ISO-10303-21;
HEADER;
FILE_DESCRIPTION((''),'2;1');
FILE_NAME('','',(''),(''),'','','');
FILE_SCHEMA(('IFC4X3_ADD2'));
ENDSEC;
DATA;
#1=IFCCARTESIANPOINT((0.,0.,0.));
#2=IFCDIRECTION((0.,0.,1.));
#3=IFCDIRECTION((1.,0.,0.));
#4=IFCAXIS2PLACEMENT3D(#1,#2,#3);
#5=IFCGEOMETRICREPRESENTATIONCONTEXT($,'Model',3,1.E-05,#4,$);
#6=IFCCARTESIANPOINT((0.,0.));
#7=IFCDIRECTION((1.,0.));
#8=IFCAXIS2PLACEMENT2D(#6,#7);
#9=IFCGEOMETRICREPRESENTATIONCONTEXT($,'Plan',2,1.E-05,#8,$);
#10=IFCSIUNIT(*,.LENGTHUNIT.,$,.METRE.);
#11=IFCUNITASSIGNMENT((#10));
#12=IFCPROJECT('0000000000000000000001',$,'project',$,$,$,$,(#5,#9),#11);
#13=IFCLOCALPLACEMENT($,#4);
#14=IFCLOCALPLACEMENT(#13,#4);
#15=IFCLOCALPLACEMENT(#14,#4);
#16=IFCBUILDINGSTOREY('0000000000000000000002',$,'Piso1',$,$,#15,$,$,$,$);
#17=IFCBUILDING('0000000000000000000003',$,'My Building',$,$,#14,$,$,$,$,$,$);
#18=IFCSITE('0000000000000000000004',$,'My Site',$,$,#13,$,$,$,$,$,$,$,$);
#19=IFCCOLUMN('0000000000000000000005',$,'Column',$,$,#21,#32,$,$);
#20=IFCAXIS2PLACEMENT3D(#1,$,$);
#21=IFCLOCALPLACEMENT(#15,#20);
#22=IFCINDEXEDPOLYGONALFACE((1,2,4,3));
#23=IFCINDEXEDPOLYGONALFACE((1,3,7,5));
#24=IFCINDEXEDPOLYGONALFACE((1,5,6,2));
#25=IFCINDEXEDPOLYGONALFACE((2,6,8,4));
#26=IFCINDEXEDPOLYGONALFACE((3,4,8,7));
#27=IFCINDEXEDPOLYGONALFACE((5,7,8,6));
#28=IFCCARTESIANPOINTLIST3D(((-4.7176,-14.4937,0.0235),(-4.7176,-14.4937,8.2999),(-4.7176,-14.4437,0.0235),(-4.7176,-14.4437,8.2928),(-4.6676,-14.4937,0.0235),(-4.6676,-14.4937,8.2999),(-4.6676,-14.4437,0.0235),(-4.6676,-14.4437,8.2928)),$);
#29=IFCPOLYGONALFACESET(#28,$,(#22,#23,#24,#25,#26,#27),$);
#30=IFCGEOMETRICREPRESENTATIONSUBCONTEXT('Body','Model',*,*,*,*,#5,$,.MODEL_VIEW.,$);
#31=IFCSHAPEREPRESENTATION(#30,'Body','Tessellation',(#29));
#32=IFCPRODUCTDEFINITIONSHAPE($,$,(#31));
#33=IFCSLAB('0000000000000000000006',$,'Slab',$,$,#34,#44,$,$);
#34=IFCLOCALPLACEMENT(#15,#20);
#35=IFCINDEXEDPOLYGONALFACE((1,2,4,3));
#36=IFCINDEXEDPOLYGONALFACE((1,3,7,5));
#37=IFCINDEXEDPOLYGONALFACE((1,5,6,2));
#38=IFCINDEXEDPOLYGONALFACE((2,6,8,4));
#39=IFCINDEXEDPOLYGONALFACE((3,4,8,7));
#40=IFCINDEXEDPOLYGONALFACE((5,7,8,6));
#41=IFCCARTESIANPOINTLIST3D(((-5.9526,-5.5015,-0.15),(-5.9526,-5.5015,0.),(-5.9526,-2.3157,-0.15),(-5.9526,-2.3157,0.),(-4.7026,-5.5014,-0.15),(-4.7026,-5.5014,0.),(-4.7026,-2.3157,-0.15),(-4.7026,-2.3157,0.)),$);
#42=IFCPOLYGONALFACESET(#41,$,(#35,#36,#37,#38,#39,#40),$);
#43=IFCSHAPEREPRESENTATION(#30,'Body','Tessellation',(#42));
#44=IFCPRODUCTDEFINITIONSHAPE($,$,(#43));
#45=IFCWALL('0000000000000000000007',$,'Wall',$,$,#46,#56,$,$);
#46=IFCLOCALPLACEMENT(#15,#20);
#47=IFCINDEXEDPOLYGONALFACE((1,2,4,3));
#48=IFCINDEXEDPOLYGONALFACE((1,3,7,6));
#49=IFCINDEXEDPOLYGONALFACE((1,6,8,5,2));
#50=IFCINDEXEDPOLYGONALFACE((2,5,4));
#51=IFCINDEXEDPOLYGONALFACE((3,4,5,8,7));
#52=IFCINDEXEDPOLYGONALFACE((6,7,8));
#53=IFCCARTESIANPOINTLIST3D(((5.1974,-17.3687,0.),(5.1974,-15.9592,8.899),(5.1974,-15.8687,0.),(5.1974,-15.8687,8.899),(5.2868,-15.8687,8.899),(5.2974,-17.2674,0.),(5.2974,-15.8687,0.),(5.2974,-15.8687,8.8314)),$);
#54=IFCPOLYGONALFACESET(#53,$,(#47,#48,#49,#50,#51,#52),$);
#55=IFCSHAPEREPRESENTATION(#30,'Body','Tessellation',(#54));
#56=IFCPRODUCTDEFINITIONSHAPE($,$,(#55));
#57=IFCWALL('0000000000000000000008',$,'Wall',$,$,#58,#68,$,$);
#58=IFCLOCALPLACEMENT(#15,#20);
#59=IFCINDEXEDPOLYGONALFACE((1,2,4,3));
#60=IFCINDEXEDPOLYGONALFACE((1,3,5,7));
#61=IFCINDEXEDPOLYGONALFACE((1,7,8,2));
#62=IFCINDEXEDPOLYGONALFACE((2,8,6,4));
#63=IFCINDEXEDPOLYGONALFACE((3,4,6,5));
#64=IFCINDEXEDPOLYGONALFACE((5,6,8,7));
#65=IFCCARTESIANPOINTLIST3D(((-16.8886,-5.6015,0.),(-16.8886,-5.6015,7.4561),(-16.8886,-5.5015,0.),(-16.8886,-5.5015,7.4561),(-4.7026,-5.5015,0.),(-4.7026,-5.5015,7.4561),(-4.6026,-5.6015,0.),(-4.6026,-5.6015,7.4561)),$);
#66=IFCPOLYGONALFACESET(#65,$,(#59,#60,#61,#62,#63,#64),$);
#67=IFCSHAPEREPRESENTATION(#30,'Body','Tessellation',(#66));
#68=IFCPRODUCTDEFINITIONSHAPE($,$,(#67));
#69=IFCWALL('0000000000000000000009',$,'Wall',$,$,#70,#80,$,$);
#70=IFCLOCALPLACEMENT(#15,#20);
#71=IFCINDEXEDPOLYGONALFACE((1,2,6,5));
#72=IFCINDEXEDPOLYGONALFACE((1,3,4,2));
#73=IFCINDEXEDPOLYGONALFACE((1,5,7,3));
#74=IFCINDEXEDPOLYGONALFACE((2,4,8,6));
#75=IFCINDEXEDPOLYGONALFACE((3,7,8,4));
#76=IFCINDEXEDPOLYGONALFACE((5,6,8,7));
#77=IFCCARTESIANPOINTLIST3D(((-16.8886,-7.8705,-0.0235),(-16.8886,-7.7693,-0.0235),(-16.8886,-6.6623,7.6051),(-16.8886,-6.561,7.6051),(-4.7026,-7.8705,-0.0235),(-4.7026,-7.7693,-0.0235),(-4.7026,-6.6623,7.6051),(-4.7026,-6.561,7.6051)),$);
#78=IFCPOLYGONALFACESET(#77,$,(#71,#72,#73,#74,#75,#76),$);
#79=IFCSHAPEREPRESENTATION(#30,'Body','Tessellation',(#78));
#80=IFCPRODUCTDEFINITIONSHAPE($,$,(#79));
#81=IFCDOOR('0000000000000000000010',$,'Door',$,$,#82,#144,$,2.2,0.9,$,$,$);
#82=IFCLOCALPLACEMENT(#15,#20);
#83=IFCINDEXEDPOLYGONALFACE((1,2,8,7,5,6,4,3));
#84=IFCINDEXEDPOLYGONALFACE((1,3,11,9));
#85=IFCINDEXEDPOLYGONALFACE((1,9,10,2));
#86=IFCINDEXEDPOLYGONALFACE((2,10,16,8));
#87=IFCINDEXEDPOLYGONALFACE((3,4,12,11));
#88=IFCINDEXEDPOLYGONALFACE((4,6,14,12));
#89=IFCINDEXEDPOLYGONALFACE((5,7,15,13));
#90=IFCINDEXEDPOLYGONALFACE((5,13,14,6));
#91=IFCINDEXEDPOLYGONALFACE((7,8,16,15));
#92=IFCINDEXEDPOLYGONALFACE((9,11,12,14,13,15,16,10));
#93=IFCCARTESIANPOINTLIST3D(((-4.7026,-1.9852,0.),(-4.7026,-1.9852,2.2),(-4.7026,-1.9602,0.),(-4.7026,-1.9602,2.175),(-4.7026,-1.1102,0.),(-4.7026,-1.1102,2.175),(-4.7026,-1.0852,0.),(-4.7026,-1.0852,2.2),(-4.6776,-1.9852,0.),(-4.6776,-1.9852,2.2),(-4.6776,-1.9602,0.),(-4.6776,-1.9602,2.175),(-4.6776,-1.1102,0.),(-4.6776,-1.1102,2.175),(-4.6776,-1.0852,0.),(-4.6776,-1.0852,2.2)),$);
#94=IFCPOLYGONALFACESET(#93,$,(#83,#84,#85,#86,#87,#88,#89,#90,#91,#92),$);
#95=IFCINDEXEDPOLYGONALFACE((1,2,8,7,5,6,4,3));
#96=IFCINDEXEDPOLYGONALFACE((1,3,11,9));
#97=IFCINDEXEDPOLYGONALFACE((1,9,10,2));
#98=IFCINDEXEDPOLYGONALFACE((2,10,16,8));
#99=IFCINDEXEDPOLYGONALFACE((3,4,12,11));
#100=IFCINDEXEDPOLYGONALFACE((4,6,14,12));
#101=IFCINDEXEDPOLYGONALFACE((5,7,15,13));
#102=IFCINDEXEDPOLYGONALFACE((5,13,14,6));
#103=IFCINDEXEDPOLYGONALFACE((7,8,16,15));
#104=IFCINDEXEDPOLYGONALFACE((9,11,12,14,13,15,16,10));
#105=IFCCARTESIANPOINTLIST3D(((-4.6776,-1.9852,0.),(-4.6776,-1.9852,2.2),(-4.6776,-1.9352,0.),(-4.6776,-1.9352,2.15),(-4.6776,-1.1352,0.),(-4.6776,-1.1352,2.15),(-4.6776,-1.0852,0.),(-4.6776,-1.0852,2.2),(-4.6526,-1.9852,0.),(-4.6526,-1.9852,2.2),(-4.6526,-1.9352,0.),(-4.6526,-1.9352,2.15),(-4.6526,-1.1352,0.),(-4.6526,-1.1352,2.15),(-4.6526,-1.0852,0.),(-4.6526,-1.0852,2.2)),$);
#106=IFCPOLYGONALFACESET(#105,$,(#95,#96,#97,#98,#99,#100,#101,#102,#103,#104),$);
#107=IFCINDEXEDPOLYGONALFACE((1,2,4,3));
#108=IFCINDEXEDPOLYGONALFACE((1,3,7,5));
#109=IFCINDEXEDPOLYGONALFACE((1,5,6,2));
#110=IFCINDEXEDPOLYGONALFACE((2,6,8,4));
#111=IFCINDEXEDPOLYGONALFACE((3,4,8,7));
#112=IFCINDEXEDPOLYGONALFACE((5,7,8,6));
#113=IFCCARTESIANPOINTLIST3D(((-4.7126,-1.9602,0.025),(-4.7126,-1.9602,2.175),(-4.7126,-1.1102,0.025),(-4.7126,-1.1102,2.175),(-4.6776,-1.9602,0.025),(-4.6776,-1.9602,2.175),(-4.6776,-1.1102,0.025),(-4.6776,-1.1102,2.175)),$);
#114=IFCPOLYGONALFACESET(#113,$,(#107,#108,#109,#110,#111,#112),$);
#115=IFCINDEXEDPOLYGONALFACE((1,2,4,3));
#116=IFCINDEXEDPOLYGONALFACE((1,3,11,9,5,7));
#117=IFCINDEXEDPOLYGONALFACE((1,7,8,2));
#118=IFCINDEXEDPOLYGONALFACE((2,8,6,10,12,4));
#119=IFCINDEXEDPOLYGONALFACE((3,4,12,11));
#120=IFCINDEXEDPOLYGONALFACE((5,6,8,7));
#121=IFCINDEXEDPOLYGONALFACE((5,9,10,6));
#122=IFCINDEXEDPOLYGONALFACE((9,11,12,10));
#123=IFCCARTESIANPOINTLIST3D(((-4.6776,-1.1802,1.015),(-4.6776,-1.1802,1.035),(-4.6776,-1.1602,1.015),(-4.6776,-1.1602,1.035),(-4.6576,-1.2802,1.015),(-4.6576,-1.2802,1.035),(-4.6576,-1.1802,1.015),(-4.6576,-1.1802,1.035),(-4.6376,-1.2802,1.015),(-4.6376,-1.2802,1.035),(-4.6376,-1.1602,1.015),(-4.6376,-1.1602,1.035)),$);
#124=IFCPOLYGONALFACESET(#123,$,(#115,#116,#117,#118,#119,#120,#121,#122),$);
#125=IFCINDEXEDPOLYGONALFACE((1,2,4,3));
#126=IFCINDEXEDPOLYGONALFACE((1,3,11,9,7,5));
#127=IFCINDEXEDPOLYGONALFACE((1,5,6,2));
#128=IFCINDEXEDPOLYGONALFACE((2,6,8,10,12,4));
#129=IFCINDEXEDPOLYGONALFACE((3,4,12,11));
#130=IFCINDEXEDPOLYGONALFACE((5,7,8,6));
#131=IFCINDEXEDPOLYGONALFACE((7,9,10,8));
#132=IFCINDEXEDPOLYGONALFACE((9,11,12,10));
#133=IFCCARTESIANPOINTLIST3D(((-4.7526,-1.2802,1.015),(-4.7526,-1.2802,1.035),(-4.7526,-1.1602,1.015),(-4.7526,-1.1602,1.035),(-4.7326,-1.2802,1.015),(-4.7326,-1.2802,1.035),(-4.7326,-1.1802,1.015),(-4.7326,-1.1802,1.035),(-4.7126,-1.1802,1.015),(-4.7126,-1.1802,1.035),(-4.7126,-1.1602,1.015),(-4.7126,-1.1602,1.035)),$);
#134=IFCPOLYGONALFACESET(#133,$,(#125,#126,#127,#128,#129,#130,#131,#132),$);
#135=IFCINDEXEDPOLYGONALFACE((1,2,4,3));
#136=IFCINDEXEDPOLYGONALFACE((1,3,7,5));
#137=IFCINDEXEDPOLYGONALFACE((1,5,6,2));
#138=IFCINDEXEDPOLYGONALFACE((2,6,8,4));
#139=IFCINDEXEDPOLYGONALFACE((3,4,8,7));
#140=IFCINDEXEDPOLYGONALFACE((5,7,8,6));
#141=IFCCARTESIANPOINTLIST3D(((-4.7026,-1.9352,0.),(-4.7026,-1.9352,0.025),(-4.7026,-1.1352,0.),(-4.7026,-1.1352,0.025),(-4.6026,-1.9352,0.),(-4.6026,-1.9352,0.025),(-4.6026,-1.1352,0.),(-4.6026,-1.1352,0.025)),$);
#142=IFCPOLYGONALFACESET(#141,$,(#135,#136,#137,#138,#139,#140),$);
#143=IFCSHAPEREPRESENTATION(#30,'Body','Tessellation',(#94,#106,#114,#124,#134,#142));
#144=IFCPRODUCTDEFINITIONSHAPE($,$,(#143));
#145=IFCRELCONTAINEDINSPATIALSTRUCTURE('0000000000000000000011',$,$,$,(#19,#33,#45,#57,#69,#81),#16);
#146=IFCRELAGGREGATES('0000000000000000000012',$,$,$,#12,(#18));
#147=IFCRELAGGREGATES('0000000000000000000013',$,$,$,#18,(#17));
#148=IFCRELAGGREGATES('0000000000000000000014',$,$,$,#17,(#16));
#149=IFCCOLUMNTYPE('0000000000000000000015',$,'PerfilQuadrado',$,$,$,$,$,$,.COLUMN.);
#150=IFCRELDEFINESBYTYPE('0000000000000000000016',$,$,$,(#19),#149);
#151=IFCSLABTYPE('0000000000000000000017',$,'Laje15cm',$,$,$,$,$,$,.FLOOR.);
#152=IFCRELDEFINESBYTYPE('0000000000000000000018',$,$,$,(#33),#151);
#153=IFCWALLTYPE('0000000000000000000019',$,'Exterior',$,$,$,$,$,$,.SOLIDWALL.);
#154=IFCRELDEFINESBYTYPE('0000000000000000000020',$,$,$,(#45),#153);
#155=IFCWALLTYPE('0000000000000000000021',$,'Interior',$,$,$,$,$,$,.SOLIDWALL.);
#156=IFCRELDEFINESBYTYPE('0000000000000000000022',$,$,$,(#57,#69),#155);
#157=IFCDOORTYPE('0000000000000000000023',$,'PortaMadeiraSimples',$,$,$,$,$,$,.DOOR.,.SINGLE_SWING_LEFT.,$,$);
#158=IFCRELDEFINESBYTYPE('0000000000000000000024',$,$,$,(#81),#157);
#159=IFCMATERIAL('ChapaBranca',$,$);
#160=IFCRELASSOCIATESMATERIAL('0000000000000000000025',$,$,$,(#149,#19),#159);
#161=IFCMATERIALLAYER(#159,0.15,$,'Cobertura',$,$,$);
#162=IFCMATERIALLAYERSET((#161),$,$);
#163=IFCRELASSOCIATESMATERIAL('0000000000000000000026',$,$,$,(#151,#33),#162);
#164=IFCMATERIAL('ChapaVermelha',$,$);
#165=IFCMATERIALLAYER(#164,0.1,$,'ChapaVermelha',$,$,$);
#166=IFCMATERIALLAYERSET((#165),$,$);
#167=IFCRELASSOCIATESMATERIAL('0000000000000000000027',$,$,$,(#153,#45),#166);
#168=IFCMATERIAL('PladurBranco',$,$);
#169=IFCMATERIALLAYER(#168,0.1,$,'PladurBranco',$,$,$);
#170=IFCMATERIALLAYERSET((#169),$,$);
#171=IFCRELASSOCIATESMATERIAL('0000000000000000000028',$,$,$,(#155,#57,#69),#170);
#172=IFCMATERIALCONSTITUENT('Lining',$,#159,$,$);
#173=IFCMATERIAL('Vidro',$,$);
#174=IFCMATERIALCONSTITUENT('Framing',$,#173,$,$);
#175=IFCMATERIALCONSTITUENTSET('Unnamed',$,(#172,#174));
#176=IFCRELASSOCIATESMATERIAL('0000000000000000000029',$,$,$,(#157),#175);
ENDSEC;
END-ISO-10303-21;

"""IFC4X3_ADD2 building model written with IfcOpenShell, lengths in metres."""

from ifc_helpers import new_model, entity, si_unit, frame, origin_with_axes, origin_2d, origin_2d_with_axis, place, context, subcontext, project, spatial, line, indexed_curve, rectangle, outline, extrude, boolean, clip, halfspace, shape, source, transform, mapped, material, layer, layer_set, layer_usage, constituent, constituent_set, material_profile, profile_set, profile_usage, type_object, type_shapes, element, save


model = new_model("IFC4X3_ADD2")

# Units and contexts
model_context = context("Model", 3, precision=1e-05, world=origin_with_axes())
plan_context = context("Plan", 2, precision=1e-05, world=origin_2d_with_axis())
body_context_1 = subcontext(model_context, "Body", "Model", "MODEL_VIEW")
body_context_2 = subcontext(plan_context, "Body", "Plan", "PLAN_VIEW")
ifc_project = project(units=[si_unit("LENGTHUNIT", "METRE")], contexts=[model_context, plan_context])

# Site, building, storey
site_placement = place(None, origin_with_axes())
site = spatial("IfcSite", under=ifc_project, at=site_placement, Name="My Site")
building_placement = place(site_placement, origin_with_axes())
building = spatial("IfcBuilding", under=site, at=building_placement, Name="My Building")
storey_placement = place(building_placement, origin_with_axes())
storey = spatial("IfcBuildingStorey", under=building, at=storey_placement, Name="Piso1")

# Column
ifc_material_1 = material(Name="ChapaBranca")
ifc_material_profile_1 = material_profile(ifc_material_1, rectangle(XDim=0.05, YDim=0.05, at=origin_2d()))
ifc_profile_set_1 = profile_set([ifc_material_profile_1])
column_type_1 = type_object("IfcColumnType", Name="PerfilQuadrado", PredefinedType="COLUMN", material=ifc_profile_set_1)
ifc_profile_usage_1 = profile_usage(ifc_profile_set_1, cardinal=5)
column_1_placement = place(storey_placement, frame((-4.6926, -14.4687, 0.0235), z_axis=(0.0, 0.0, 1.0), x_axis=(0.0, 1.0, 0.0)))
element("IfcColumn", 1, at=column_1_placement, inside=storey, type_object=column_type_1, material=ifc_profile_usage_1, Name="Column", context=body_context_1, shape_type="Clipping", body=[
    clip(extrude(rectangle(XDim=0.05, YDim=0.05, at=origin_2d()), origin_with_axes(), (0.0, 0.0, 1.0), 8.3229), halfspace(frame((-1.3416, 0.0, 8.4614), z_axis=(0.139173, 0.0, 0.990268), x_axis=(0.0, -1.0, 0.0)), False)),
])

# Slab
ifc_layer_1 = layer(ifc_material_1, 0.15, Name="Cobertura")
ifc_layer_set_1 = layer_set([ifc_layer_1])
ifc_layer_usage_1 = layer_usage(ifc_layer_set_1, "AXIS3", "POSITIVE", -0.3)
slab_type_1 = type_object("IfcSlabType", Name="Laje15cm", PredefinedType="FLOOR", material=ifc_layer_set_1)
slab_1_placement = place(storey_placement, frame((-5.9526, -5.5015, 0.15), z_axis=(0.0, 0.0, 1.0), x_axis=(1.0, 0.0, 0.0)))
element("IfcSlab", 2, at=slab_1_placement, inside=storey, type_object=slab_type_1, material=ifc_layer_usage_1, Name="Slab", context=body_context_1, shape_type="SweptSolid", body=[
    extrude(outline(indexed_curve([(0.0, 0.0), (0.0, 3.1858), (1.25, 3.1858), (1.25, 0.0001), (0.0, 0.0)])), frame((0.0, 0.0, -0.3), z_axis=(0.0, 0.0, 1.0), x_axis=(1.0, 0.0, 0.0)), (0.0, 0.0, 1.0), 0.15),
])

# Shared definitions
ifc_material_2 = material(Name="ChapaVermelha")
ifc_layer_2 = layer(ifc_material_2, 0.1, Name="ChapaVermelha")
ifc_layer_set_2 = layer_set([ifc_layer_2])
wall_type_1 = type_object("IfcWallType", Name="Exterior", PredefinedType="SOLIDWALL", material=ifc_layer_set_2)

# Walls
ifc_layer_usage_2 = layer_usage(ifc_layer_set_2, "AXIS2", "POSITIVE", 0.0)
wall_1_placement = place(storey_placement, frame((5.1974, -15.8687, 0.0), z_axis=(0.0, 0.0, 1.0), x_axis=(0.0, -1.0, 0.0)))
element("IfcWall", 3, at=wall_1_placement, inside=storey, type_object=wall_type_1, material=ifc_layer_usage_2, Name="Wall", context=body_context_1, shape_type="CSG", body=[
    boolean("DIFFERENCE", extrude(outline(indexed_curve([(0.0, 0.0), (0.0, 0.1), (1.3988, 0.1), (1.5, 0.0)], segments=[line(1, 2, 3, 4, 1)])), origin_with_axes(), (0.0, 0.0, 1.0), 8.899), extrude(outline(indexed_curve([(1.5, 0.0), (1.3988, 0.1), (2.9095, 0.1), (2.9095, 0.0)], segments=[line(1, 2, 3, 4, 1)])), origin_with_axes(), (-0.156434, 0.0, 0.987688), 9.0099)),
])
ifc_material_3 = material(Name="PladurBranco")
ifc_layer_3 = layer(ifc_material_3, 0.1, Name="PladurBranco")
ifc_layer_set_3 = layer_set([ifc_layer_3])
wall_type_2 = type_object("IfcWallType", Name="Interior", PredefinedType="SOLIDWALL", material=ifc_layer_set_3)
ifc_layer_usage_3 = layer_usage(ifc_layer_set_3, "AXIS2", "POSITIVE", 0.0)
wall_2_placement = place(storey_placement, frame((-16.8886, -5.6015, 0.0), z_axis=(0.0, 0.0, 1.0), x_axis=(1.0, 0.0, 0.0)))
element("IfcWall", 4, at=wall_2_placement, inside=storey, type_object=wall_type_2, material=ifc_layer_usage_3, Name="Wall", context=body_context_1, shape_type="SweptSolid", body=[
    extrude(outline(indexed_curve([(0.0, 0.0), (0.0, 0.1), (12.186, 0.1), (12.286, 0.0)], segments=[line(1, 2, 3, 4, 1)])), origin_with_axes(), (0.0, 0.0, 1.0), 7.4561),
])
ifc_layer_usage_4 = layer_usage(ifc_layer_set_3, "AXIS2", "POSITIVE", 0.0)
wall_3_placement = place(storey_placement, frame((-16.8886, -7.8705, -0.0235), z_axis=(0.0, 0.0, 1.0), x_axis=(1.0, 0.0, 0.0)))
element("IfcWall", 5, at=wall_3_placement, inside=storey, type_object=wall_type_2, material=ifc_layer_usage_4, Name="Wall", context=body_context_1, shape_type="SweptSolid", body=[
    extrude(outline(indexed_curve([(0.0, 0.0), (0.0, 0.1012), (12.186, 0.1012), (12.186, 0.0)], segments=[line(1, 2, 3, 4, 1)])), origin_with_axes(), (0.0, 0.156434, 0.987688), 7.7237),
])

# Door
ifc_constituent_1 = constituent(ifc_material_1, Name="Lining")
ifc_material_4 = material(Name="Vidro")
ifc_constituent_2 = constituent(ifc_material_4, Name="Framing")
ifc_constituent_set = constituent_set(constituents=[ifc_constituent_1, ifc_constituent_2], Name="Unnamed")
door_type = type_object("IfcDoorType", Name="PortaMadeiraSimples", OperationType="SINGLE_SWING_LEFT", PredefinedType="DOOR", material=ifc_constituent_set)
shared_shape_1 = source(origin_with_axes(), body_context_1, "Body", "SweptSolid", [
    extrude(outline(indexed_curve([(0.0, 0.0), (0.0, 2.2), (0.9, 2.2), (0.9, 0.0), (0.875, 0.0), (0.875, 2.175), (0.025, 2.175), (0.025, 0.0)], segments=[line(1, 2, 3, 4, 5, 6, 7, 8, 1)])), frame((0.0, 0.075, 0.0), z_axis=(0.0, -1.0, 0.0), x_axis=(1.0, 0.0, 0.0)), (0.0, 0.0, -1.0), 0.025),
    extrude(outline(indexed_curve([(0.0, 0.0), (0.0, 2.2), (0.9, 2.2), (0.9, 0.0), (0.85, 0.0), (0.85, 2.15), (0.05, 2.15), (0.05, 0.0)], segments=[line(1, 2, 3, 4, 5, 6, 7, 8, 1)])), frame((0.0, 0.05, 0.0), z_axis=(0.0, -1.0, 0.0), x_axis=(1.0, 0.0, 0.0)), (0.0, 0.0, -1.0), 0.025),
    extrude(outline(indexed_curve([(0.0, 0.0), (0.85, 0.0), (0.85, 0.035), (0.0, 0.035)], segments=[line(1, 2, 3, 4, 1)])), frame((0.025, 0.075, 0.025), z_axis=(0.0, 0.0, 1.0), x_axis=(1.0, 0.0, 0.0)), (0.0, 0.0, 1.0), 2.15),
    extrude(outline(indexed_curve([(0.0, 0.0), (0.0, -0.04), (-0.12, -0.04), (-0.12, -0.02), (-0.02, -0.02), (-0.02, 0.0)], segments=[line(1, 2, 3, 4, 5, 6, 1)])), frame((0.825, 0.075, 1.015), z_axis=(0.0, 0.0, 1.0), x_axis=(1.0, 0.0, 0.0)), (0.0, 0.0, 1.0), 0.02),
    extrude(outline(indexed_curve([(0.0, 0.0), (0.0, 0.04), (-0.12, 0.04), (-0.12, 0.02), (-0.02, 0.02), (-0.02, 0.0)], segments=[line(1, 2, 3, 4, 5, 6, 1)])), frame((0.825, 0.11, 1.015), z_axis=(0.0, 0.0, 1.0), x_axis=(1.0, 0.0, 0.0)), (0.0, 0.0, 1.0), 0.02),
    extrude(outline(indexed_curve([(0.0, 0.0), (0.8, 0.0), (0.8, 0.1), (0.0, 0.1)], segments=[line(1, 2, 3, 4, 1)])), frame((0.05, 0.0, 0.0), z_axis=(0.0, 0.0, 1.0), x_axis=(1.0, 0.0, 0.0)), (0.0, 0.0, 1.0), 0.025),
])
shared_shape_2 = source(origin_with_axes(), body_context_2, "Body", "Curve2D", [
    entity("IfcIndexedPolyCurve", entity("IfcCartesianPointList2D", [[0.0, 0.05], [0.0, 0.1], [0.025, 0.1], [0.025, 0.075], [0.05, 0.075], [0.05, 0.05]]), [entity("IfcLineIndex", [1, 2, 3, 4, 5, 6, 1])]),
    entity("IfcIndexedPolyCurve", entity("IfcCartesianPointList2D", [[0.9, 0.05], [0.9, 0.1], [0.875, 0.1], [0.875, 0.075], [0.85, 0.075], [0.85, 0.05]]), [entity("IfcLineIndex", [1, 2, 3, 4, 5, 6, 1])]),
    entity("IfcTrimmedCurve", entity("IfcCircle", entity("IfcAxis2Placement2D", entity("IfcCartesianPoint", [0.025, 0.1]), entity("IfcDirection", [1.0, 0.0])), 0.85), [entity("IfcCartesianPoint", [0.875, 0.1])], [entity("IfcCartesianPoint", [0.025, 0.95])], True, "CARTESIAN"),
    entity("IfcIndexedPolyCurve", entity("IfcCartesianPointList2D", [[0.025, 0.1], [0.06, 0.1], [0.06, 0.95], [0.025, 0.95]]), [entity("IfcLineIndex", [1, 2, 3, 4, 1])]),
])
type_shapes(door_type, [shared_shape_1, shared_shape_2])
door_placement = place(storey_placement, frame((-4.6026, -1.9852, 0.0), z_axis=(0.0, 0.0, 1.0), x_axis=(0.0, 1.0, 0.0)))
element("IfcDoor", 6, at=door_placement, inside=storey, type_object=door_type, Name="Door", OverallHeight=2.2, OverallWidth=0.9, shapes=[
    shape(body_context_1, "Body", "MappedRepresentation", [mapped(shared_shape_1, transform((0.0, 0.0, 0.0), x_axis=(1.0, 0.0, 0.0), y_axis=(0.0, 1.0, 0.0), z_axis=(0.0, 0.0, 1.0), scale=1.0))]),
    shape(body_context_2, "Body", "MappedRepresentation", [mapped(shared_shape_2, transform((0.0, 0.0, 0.0), x_axis=(1.0, 0.0, 0.0), y_axis=(0.0, 1.0, 0.0), z_axis=(0.0, 0.0, 1.0), scale=1.0))]),
])

save(model, "model.ifc")
